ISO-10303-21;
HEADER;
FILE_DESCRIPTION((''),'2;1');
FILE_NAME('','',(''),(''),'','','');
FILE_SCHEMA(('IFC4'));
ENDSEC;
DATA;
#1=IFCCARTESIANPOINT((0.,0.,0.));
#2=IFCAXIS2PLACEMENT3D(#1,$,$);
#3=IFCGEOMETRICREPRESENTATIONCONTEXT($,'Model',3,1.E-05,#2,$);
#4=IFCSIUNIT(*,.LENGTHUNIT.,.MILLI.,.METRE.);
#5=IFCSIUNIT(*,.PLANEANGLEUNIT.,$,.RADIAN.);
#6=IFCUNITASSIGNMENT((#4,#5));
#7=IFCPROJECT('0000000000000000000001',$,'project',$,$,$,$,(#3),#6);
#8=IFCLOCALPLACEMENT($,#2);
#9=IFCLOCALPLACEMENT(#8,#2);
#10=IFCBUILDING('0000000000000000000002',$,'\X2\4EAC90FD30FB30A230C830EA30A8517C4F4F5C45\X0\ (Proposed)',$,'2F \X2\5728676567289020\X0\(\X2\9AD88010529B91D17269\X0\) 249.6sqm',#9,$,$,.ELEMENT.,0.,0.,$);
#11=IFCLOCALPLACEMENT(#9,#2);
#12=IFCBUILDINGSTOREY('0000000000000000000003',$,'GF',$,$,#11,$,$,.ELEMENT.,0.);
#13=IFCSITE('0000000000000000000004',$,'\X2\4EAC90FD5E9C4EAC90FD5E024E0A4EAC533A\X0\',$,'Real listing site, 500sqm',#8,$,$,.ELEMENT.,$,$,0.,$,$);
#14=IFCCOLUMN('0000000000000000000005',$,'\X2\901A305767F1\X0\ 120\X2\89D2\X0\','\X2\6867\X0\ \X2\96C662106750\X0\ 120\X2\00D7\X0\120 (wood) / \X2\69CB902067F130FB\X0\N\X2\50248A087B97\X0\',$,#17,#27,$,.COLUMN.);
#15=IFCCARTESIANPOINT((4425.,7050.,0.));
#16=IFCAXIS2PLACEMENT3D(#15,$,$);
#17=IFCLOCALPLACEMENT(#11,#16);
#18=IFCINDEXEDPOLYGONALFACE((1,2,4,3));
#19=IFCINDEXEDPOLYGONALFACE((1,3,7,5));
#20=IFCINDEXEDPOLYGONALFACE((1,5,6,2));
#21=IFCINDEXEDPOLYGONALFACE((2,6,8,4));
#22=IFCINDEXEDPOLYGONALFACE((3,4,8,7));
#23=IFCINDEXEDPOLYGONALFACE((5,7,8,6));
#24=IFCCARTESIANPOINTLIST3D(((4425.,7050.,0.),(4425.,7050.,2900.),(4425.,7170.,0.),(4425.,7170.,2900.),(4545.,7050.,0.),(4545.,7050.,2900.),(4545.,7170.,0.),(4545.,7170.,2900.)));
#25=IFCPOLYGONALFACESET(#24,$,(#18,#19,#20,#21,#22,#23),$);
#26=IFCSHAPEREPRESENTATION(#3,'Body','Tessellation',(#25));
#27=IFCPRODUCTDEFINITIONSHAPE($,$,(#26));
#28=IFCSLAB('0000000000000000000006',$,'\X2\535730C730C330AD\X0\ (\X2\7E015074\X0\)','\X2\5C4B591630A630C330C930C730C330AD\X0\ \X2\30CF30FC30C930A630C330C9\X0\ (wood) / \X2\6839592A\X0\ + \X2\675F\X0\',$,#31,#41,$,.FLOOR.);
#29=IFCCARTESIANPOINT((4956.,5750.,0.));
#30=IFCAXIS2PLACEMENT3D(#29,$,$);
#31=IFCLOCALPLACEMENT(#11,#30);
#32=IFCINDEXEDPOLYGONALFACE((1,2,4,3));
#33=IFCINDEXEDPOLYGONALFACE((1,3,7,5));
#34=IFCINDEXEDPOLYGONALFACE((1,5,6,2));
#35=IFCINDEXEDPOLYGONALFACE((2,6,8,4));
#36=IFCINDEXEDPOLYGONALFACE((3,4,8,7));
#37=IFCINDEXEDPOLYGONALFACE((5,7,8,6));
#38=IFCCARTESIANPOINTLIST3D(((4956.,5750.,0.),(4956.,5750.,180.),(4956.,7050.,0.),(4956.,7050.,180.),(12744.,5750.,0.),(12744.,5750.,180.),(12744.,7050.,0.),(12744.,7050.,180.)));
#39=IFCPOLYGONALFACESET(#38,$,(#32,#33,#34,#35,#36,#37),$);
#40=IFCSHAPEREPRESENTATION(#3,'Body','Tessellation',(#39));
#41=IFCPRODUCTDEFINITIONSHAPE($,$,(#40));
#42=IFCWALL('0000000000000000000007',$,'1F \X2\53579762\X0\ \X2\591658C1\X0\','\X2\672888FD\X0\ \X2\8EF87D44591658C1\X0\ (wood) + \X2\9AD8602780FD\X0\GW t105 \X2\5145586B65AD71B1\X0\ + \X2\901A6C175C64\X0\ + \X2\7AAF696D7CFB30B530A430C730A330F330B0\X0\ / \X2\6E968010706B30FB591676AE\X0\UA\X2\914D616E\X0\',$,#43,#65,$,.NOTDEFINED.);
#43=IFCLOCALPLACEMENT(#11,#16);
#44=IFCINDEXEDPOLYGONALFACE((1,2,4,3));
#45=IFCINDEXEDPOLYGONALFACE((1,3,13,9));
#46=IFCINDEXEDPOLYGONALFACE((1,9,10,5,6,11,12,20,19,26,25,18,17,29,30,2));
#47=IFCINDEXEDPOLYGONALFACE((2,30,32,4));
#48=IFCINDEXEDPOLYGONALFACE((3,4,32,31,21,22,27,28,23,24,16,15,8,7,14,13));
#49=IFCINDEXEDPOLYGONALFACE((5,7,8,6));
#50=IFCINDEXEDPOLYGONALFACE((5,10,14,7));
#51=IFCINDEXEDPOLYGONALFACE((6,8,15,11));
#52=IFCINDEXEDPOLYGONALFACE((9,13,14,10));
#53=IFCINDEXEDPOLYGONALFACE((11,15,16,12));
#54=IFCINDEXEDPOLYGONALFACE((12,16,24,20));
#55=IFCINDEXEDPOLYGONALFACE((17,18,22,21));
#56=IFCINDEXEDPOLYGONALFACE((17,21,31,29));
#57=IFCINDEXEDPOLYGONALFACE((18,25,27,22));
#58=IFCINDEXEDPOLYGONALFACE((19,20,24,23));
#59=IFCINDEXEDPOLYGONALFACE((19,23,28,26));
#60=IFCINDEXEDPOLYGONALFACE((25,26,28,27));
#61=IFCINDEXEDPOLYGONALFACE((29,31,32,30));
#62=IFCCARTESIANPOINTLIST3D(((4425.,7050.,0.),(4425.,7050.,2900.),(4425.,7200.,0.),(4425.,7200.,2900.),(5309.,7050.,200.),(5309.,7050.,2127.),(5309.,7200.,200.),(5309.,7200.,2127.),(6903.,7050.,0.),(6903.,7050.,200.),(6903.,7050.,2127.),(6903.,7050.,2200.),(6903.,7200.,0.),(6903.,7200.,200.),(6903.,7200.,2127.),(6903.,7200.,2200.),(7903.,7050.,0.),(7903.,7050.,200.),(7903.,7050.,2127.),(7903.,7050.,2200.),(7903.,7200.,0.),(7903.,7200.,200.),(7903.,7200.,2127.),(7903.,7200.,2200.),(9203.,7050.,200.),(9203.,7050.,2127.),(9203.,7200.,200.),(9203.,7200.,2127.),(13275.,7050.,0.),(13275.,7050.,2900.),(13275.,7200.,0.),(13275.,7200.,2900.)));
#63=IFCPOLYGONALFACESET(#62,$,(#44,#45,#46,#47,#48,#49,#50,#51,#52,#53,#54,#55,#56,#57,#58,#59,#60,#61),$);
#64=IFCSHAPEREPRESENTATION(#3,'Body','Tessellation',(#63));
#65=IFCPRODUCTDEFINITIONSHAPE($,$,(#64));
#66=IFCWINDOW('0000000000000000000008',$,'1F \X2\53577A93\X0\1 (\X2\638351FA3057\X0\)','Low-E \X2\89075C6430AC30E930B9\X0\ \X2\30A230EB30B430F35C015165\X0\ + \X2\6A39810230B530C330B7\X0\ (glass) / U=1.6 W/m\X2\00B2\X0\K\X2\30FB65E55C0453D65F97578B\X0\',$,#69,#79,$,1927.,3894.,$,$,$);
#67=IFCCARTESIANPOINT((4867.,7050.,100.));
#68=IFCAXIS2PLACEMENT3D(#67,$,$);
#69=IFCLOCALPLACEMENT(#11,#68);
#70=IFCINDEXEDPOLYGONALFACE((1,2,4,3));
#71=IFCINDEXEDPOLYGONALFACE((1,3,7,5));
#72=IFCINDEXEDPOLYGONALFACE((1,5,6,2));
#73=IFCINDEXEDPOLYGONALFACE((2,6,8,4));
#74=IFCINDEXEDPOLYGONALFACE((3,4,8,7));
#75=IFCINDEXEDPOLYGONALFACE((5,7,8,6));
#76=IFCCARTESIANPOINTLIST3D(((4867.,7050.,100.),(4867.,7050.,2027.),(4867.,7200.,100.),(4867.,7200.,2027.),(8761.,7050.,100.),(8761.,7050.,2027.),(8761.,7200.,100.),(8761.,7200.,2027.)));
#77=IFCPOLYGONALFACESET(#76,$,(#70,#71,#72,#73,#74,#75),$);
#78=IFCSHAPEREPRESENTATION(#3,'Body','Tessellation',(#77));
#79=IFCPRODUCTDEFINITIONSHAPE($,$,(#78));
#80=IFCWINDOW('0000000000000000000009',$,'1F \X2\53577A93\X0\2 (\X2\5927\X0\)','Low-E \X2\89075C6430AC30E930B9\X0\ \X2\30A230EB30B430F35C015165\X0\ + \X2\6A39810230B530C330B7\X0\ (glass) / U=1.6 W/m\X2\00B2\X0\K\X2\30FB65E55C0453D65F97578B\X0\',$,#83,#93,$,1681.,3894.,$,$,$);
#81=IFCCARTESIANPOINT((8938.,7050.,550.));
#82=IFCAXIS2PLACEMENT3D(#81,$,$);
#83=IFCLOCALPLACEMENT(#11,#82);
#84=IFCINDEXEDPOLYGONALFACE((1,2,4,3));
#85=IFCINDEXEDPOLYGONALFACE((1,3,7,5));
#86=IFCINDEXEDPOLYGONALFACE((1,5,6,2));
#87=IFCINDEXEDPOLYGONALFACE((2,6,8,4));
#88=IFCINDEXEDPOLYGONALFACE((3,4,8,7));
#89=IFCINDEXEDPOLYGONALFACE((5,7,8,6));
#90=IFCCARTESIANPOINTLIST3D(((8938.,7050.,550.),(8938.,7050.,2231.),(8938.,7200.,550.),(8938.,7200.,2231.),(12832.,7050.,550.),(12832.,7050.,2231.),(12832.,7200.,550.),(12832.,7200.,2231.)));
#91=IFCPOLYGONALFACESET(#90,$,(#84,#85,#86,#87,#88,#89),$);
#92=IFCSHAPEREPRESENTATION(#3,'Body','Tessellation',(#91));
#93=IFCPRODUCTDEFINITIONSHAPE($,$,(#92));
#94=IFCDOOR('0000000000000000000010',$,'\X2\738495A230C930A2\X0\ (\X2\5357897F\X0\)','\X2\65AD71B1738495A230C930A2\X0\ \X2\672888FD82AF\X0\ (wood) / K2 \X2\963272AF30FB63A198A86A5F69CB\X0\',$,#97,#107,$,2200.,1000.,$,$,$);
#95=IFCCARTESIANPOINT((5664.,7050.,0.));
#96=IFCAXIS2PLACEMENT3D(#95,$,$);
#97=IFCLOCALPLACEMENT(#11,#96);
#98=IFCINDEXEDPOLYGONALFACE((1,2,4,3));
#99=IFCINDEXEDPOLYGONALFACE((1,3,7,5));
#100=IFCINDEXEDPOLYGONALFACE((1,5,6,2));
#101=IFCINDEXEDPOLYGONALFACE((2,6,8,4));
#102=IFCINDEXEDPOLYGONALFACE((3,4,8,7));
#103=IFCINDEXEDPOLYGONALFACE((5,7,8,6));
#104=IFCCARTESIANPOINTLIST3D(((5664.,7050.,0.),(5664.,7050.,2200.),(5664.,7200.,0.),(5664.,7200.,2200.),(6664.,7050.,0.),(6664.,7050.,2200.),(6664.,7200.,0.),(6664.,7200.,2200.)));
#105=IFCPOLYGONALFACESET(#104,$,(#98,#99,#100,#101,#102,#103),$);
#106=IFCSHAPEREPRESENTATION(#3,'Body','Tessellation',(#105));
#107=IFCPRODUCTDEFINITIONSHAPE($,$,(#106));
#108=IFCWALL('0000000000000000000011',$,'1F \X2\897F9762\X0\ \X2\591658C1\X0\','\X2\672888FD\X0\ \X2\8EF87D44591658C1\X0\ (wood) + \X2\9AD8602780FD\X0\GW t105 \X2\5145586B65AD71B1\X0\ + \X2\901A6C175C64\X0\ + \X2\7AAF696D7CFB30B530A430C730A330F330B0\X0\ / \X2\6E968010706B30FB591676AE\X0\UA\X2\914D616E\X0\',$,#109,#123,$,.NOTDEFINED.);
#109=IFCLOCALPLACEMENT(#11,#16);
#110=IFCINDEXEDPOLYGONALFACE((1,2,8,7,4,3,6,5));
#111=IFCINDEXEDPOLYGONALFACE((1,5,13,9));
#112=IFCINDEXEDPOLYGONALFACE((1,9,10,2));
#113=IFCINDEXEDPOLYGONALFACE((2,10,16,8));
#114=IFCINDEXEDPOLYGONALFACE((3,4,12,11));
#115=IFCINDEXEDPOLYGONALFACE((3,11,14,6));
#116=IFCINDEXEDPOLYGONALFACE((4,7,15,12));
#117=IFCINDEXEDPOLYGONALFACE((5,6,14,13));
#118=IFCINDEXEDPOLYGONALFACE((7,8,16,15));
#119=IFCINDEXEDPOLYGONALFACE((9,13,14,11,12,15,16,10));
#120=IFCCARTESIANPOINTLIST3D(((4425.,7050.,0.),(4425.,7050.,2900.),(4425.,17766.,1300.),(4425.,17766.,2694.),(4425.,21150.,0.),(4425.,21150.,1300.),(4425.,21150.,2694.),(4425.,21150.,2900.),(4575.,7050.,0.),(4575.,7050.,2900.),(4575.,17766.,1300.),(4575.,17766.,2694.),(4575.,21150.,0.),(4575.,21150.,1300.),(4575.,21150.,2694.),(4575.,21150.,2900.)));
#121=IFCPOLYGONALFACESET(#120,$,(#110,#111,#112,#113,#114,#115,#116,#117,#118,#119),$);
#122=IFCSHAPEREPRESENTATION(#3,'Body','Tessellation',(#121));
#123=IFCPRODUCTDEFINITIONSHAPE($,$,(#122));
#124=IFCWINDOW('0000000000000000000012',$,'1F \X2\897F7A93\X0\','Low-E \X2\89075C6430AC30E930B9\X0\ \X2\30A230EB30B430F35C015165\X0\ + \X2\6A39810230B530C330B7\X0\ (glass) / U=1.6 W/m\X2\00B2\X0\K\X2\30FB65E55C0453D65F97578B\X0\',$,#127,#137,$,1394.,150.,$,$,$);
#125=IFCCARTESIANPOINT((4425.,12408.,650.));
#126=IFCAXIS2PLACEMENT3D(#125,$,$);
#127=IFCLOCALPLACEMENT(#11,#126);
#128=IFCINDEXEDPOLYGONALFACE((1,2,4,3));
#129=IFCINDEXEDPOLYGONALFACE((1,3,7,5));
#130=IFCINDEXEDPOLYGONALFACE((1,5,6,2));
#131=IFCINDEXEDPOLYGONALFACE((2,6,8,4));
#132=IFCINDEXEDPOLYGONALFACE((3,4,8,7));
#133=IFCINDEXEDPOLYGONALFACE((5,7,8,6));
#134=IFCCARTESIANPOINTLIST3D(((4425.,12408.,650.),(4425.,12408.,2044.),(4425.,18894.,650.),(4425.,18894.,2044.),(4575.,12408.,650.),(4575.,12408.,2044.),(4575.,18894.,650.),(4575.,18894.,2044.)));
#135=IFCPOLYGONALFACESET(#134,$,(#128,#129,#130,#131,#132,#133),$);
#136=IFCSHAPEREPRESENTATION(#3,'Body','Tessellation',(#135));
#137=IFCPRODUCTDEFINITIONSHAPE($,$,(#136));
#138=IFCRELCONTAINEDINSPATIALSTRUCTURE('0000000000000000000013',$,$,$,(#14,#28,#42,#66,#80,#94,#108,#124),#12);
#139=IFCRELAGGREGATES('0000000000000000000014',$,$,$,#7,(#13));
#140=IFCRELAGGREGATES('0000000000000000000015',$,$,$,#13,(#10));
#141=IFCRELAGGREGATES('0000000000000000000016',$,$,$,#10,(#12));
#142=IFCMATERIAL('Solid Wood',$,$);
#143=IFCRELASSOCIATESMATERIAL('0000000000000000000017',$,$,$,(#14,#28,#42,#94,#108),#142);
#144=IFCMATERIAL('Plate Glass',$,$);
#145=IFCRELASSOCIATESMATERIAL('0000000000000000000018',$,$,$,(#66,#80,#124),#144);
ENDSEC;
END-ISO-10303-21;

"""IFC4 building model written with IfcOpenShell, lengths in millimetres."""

from ifc_helpers import new_model, si_unit, frame, frame_2d, origin, place, context, project, spatial, rectangle, extrude, material, element, fill, save


model = new_model("IFC4")

# Units and contexts
model_context = context("Model", 3, precision=1e-05, world=origin())
ifc_project = project(units=[si_unit("LENGTHUNIT", "METRE", prefix="MILLI"), si_unit("PLANEANGLEUNIT", "RADIAN")], contexts=[model_context])

# Site, building, storey
site_placement = place(None, origin())
site = spatial("IfcSite", under=ifc_project, at=site_placement, Name="京都府京都市上京区", ObjectType="Real listing site, 500sqm", CompositionType="ELEMENT", RefElevation=0.0)
building_placement = place(site_placement, origin())
building = spatial("IfcBuilding", under=site, at=building_placement, Name="京都・アトリエ兼住居 (Proposed)", ObjectType="2F 在来木造(高耐力金物) 249.6sqm", CompositionType="ELEMENT", ElevationOfRefHeight=0.0, ElevationOfTerrain=0.0)
storey_placement = place(building_placement, origin())
storey = spatial("IfcBuildingStorey", under=building, at=storey_placement, Name="GF", CompositionType="ELEMENT", Elevation=0.0)

# Column
ifc_material_1 = material(Name="Solid Wood")
column_placement = place(storey_placement, frame((4425.0, 7050.0, 0.0)))
element("IfcColumn", 1, at=column_placement, inside=storey, material=ifc_material_1, Name="通し柱 120角", Description="桧 集成材 120×120 (wood) / 構造柱・N値計算", PredefinedType="COLUMN", context=model_context, shape_type="SweptSolid", body=[
    extrude(rectangle(XDim=120.0, YDim=120.0, at=frame_2d((60.0, 60.0))), frame((4425.0, 7050.0, 0.0)), (0.0, 0.0, 1.0), 2900.0),
])

# Slab
slab_1_placement = place(storey_placement, frame((4956.0, 5750.0, 0.0)))
element("IfcSlab", 2, at=slab_1_placement, inside=storey, material=ifc_material_1, Name="南デッキ (縁側)", Description="屋外ウッドデッキ ハードウッド (wood) / 根太 + 束", PredefinedType="FLOOR", context=model_context, shape_type="SweptSolid", body=[
    extrude(rectangle(XDim=7788.0, YDim=1300.0, at=frame_2d((3894.0, 650.0))), frame((4956.0, 5750.0, 0.0)), (0.0, 0.0, 1.0), 180.0),
])

# Wall, openings, windows, door
wall_1_placement = place(storey_placement, frame((4425.0, 7050.0, 0.0)))
wall_1 = element("IfcWall", 3, at=wall_1_placement, inside=storey, material=ifc_material_1, Name="1F 南面 外壁", Description="木製 軸組外壁 (wood) + 高性能GW t105 充填断熱 + 通気層 + 窯業系サイディング / 準耐火・外皮UA配慮", PredefinedType="NOTDEFINED", context=model_context, shape_type="SweptSolid", body=[
    extrude(rectangle(XDim=8850.0, YDim=150.0, at=frame_2d((4425.0, 75.0))), frame((4425.0, 7050.0, 0.0)), (0.0, 0.0, 1.0), 2900.0),
])
opening_1_placement = place(storey_placement, frame((4867.0, 7050.0, 100.0)))
opening_1 = element("IfcOpeningElement", 4, at=opening_1_placement, cuts=wall_1, PredefinedType="NOTDEFINED", context=model_context, shape_type="SweptSolid", body=[
    extrude(rectangle(XDim=3894.0, YDim=150.0, at=frame_2d((1947.0, 75.0))), frame((4867.0, 7050.0, 100.0)), (0.0, 0.0, 1.0), 1927.0),
])
opening_2_placement = place(storey_placement, frame((8938.0, 7050.0, 550.0)))
opening_2 = element("IfcOpeningElement", 5, at=opening_2_placement, cuts=wall_1, PredefinedType="NOTDEFINED", context=model_context, shape_type="SweptSolid", body=[
    extrude(rectangle(XDim=3894.0, YDim=150.0, at=frame_2d((1947.0, 75.0))), frame((8938.0, 7050.0, 550.0)), (0.0, 0.0, 1.0), 1681.0),
])
opening_3_placement = place(storey_placement, frame((5664.0, 7050.0, 0.0)))
opening_3 = element("IfcOpeningElement", 6, at=opening_3_placement, cuts=wall_1, PredefinedType="NOTDEFINED", context=model_context, shape_type="SweptSolid", body=[
    extrude(rectangle(XDim=1000.0, YDim=150.0, at=frame_2d((500.0, 75.0))), frame((5664.0, 7050.0, 0.0)), (0.0, 0.0, 1.0), 2200.0),
])
ifc_material_2 = material(Name="Plate Glass")
window_1_placement = place(storey_placement, frame((4867.0, 7050.0, 100.0)))
window_1 = element("IfcWindow", 7, at=window_1_placement, inside=storey, material=ifc_material_2, Name="1F 南窓1 (掃出し)", Description="Low-E 複層ガラス アルゴン封入 + 樹脂サッシ (glass) / U=1.6 W/m²K・日射取得型", OverallHeight=1927.0, OverallWidth=3894.0, context=model_context, shape_type="SweptSolid", body=[
    extrude(rectangle(XDim=3894.0, YDim=150.0, at=frame_2d((1947.0, 75.0))), frame((4867.0, 7050.0, 100.0)), (0.0, 0.0, 1.0), 1927.0),
])
fill(opening_1, window_1)
window_2_placement = place(storey_placement, frame((8938.0, 7050.0, 550.0)))
window_2 = element("IfcWindow", 8, at=window_2_placement, inside=storey, material=ifc_material_2, Name="1F 南窓2 (大)", Description="Low-E 複層ガラス アルゴン封入 + 樹脂サッシ (glass) / U=1.6 W/m²K・日射取得型", OverallHeight=1681.0, OverallWidth=3894.0, context=model_context, shape_type="SweptSolid", body=[
    extrude(rectangle(XDim=3894.0, YDim=150.0, at=frame_2d((1947.0, 75.0))), frame((8938.0, 7050.0, 550.0)), (0.0, 0.0, 1.0), 1681.0),
])
fill(opening_2, window_2)
door_placement = place(storey_placement, frame((5664.0, 7050.0, 0.0)))
door = element("IfcDoor", 9, at=door_placement, inside=storey, material=ifc_material_1, Name="玄関ドア (南西)", Description="断熱玄関ドア 木製芯 (wood) / K2 防犯・採風機構", OverallHeight=2200.0, OverallWidth=1000.0, context=model_context, shape_type="SweptSolid", body=[
    extrude(rectangle(XDim=1000.0, YDim=150.0, at=frame_2d((500.0, 75.0))), frame((5664.0, 7050.0, 0.0)), (0.0, 0.0, 1.0), 2200.0),
])
fill(opening_3, door)

# Wall, opening, window
wall_2_placement = place(storey_placement, frame((4425.0, 7050.0, 0.0)))
wall_2 = element("IfcWall", 10, at=wall_2_placement, inside=storey, material=ifc_material_1, Name="1F 西面 外壁", Description="木製 軸組外壁 (wood) + 高性能GW t105 充填断熱 + 通気層 + 窯業系サイディング / 準耐火・外皮UA配慮", PredefinedType="NOTDEFINED", context=model_context, shape_type="SweptSolid", body=[
    extrude(rectangle(XDim=150.0, YDim=14100.0, at=frame_2d((75.0, 7050.0))), frame((4425.0, 7050.0, 0.0)), (0.0, 0.0, 1.0), 2900.0),
])
opening_4_placement = place(storey_placement, frame((4425.0, 12408.0, 650.0)))
opening_4 = element("IfcOpeningElement", 11, at=opening_4_placement, cuts=wall_2, PredefinedType="NOTDEFINED", context=model_context, shape_type="SweptSolid", body=[
    extrude(rectangle(XDim=150.0, YDim=6486.0, at=frame_2d((75.0, 3243.0))), frame((4425.0, 12408.0, 650.0)), (0.0, 0.0, 1.0), 1394.0),
])
window_3_placement = place(storey_placement, frame((4425.0, 12408.0, 650.0)))
window_3 = element("IfcWindow", 12, at=window_3_placement, inside=storey, material=ifc_material_2, Name="1F 西窓", Description="Low-E 複層ガラス アルゴン封入 + 樹脂サッシ (glass) / U=1.6 W/m²K・日射取得型", OverallHeight=1394.0, OverallWidth=150.0, context=model_context, shape_type="SweptSolid", body=[
    extrude(rectangle(XDim=150.0, YDim=6486.0, at=frame_2d((75.0, 3243.0))), frame((4425.0, 12408.0, 650.0)), (0.0, 0.0, 1.0), 1394.0),
])
fill(opening_4, window_3)

save(model, "model.ifc")
